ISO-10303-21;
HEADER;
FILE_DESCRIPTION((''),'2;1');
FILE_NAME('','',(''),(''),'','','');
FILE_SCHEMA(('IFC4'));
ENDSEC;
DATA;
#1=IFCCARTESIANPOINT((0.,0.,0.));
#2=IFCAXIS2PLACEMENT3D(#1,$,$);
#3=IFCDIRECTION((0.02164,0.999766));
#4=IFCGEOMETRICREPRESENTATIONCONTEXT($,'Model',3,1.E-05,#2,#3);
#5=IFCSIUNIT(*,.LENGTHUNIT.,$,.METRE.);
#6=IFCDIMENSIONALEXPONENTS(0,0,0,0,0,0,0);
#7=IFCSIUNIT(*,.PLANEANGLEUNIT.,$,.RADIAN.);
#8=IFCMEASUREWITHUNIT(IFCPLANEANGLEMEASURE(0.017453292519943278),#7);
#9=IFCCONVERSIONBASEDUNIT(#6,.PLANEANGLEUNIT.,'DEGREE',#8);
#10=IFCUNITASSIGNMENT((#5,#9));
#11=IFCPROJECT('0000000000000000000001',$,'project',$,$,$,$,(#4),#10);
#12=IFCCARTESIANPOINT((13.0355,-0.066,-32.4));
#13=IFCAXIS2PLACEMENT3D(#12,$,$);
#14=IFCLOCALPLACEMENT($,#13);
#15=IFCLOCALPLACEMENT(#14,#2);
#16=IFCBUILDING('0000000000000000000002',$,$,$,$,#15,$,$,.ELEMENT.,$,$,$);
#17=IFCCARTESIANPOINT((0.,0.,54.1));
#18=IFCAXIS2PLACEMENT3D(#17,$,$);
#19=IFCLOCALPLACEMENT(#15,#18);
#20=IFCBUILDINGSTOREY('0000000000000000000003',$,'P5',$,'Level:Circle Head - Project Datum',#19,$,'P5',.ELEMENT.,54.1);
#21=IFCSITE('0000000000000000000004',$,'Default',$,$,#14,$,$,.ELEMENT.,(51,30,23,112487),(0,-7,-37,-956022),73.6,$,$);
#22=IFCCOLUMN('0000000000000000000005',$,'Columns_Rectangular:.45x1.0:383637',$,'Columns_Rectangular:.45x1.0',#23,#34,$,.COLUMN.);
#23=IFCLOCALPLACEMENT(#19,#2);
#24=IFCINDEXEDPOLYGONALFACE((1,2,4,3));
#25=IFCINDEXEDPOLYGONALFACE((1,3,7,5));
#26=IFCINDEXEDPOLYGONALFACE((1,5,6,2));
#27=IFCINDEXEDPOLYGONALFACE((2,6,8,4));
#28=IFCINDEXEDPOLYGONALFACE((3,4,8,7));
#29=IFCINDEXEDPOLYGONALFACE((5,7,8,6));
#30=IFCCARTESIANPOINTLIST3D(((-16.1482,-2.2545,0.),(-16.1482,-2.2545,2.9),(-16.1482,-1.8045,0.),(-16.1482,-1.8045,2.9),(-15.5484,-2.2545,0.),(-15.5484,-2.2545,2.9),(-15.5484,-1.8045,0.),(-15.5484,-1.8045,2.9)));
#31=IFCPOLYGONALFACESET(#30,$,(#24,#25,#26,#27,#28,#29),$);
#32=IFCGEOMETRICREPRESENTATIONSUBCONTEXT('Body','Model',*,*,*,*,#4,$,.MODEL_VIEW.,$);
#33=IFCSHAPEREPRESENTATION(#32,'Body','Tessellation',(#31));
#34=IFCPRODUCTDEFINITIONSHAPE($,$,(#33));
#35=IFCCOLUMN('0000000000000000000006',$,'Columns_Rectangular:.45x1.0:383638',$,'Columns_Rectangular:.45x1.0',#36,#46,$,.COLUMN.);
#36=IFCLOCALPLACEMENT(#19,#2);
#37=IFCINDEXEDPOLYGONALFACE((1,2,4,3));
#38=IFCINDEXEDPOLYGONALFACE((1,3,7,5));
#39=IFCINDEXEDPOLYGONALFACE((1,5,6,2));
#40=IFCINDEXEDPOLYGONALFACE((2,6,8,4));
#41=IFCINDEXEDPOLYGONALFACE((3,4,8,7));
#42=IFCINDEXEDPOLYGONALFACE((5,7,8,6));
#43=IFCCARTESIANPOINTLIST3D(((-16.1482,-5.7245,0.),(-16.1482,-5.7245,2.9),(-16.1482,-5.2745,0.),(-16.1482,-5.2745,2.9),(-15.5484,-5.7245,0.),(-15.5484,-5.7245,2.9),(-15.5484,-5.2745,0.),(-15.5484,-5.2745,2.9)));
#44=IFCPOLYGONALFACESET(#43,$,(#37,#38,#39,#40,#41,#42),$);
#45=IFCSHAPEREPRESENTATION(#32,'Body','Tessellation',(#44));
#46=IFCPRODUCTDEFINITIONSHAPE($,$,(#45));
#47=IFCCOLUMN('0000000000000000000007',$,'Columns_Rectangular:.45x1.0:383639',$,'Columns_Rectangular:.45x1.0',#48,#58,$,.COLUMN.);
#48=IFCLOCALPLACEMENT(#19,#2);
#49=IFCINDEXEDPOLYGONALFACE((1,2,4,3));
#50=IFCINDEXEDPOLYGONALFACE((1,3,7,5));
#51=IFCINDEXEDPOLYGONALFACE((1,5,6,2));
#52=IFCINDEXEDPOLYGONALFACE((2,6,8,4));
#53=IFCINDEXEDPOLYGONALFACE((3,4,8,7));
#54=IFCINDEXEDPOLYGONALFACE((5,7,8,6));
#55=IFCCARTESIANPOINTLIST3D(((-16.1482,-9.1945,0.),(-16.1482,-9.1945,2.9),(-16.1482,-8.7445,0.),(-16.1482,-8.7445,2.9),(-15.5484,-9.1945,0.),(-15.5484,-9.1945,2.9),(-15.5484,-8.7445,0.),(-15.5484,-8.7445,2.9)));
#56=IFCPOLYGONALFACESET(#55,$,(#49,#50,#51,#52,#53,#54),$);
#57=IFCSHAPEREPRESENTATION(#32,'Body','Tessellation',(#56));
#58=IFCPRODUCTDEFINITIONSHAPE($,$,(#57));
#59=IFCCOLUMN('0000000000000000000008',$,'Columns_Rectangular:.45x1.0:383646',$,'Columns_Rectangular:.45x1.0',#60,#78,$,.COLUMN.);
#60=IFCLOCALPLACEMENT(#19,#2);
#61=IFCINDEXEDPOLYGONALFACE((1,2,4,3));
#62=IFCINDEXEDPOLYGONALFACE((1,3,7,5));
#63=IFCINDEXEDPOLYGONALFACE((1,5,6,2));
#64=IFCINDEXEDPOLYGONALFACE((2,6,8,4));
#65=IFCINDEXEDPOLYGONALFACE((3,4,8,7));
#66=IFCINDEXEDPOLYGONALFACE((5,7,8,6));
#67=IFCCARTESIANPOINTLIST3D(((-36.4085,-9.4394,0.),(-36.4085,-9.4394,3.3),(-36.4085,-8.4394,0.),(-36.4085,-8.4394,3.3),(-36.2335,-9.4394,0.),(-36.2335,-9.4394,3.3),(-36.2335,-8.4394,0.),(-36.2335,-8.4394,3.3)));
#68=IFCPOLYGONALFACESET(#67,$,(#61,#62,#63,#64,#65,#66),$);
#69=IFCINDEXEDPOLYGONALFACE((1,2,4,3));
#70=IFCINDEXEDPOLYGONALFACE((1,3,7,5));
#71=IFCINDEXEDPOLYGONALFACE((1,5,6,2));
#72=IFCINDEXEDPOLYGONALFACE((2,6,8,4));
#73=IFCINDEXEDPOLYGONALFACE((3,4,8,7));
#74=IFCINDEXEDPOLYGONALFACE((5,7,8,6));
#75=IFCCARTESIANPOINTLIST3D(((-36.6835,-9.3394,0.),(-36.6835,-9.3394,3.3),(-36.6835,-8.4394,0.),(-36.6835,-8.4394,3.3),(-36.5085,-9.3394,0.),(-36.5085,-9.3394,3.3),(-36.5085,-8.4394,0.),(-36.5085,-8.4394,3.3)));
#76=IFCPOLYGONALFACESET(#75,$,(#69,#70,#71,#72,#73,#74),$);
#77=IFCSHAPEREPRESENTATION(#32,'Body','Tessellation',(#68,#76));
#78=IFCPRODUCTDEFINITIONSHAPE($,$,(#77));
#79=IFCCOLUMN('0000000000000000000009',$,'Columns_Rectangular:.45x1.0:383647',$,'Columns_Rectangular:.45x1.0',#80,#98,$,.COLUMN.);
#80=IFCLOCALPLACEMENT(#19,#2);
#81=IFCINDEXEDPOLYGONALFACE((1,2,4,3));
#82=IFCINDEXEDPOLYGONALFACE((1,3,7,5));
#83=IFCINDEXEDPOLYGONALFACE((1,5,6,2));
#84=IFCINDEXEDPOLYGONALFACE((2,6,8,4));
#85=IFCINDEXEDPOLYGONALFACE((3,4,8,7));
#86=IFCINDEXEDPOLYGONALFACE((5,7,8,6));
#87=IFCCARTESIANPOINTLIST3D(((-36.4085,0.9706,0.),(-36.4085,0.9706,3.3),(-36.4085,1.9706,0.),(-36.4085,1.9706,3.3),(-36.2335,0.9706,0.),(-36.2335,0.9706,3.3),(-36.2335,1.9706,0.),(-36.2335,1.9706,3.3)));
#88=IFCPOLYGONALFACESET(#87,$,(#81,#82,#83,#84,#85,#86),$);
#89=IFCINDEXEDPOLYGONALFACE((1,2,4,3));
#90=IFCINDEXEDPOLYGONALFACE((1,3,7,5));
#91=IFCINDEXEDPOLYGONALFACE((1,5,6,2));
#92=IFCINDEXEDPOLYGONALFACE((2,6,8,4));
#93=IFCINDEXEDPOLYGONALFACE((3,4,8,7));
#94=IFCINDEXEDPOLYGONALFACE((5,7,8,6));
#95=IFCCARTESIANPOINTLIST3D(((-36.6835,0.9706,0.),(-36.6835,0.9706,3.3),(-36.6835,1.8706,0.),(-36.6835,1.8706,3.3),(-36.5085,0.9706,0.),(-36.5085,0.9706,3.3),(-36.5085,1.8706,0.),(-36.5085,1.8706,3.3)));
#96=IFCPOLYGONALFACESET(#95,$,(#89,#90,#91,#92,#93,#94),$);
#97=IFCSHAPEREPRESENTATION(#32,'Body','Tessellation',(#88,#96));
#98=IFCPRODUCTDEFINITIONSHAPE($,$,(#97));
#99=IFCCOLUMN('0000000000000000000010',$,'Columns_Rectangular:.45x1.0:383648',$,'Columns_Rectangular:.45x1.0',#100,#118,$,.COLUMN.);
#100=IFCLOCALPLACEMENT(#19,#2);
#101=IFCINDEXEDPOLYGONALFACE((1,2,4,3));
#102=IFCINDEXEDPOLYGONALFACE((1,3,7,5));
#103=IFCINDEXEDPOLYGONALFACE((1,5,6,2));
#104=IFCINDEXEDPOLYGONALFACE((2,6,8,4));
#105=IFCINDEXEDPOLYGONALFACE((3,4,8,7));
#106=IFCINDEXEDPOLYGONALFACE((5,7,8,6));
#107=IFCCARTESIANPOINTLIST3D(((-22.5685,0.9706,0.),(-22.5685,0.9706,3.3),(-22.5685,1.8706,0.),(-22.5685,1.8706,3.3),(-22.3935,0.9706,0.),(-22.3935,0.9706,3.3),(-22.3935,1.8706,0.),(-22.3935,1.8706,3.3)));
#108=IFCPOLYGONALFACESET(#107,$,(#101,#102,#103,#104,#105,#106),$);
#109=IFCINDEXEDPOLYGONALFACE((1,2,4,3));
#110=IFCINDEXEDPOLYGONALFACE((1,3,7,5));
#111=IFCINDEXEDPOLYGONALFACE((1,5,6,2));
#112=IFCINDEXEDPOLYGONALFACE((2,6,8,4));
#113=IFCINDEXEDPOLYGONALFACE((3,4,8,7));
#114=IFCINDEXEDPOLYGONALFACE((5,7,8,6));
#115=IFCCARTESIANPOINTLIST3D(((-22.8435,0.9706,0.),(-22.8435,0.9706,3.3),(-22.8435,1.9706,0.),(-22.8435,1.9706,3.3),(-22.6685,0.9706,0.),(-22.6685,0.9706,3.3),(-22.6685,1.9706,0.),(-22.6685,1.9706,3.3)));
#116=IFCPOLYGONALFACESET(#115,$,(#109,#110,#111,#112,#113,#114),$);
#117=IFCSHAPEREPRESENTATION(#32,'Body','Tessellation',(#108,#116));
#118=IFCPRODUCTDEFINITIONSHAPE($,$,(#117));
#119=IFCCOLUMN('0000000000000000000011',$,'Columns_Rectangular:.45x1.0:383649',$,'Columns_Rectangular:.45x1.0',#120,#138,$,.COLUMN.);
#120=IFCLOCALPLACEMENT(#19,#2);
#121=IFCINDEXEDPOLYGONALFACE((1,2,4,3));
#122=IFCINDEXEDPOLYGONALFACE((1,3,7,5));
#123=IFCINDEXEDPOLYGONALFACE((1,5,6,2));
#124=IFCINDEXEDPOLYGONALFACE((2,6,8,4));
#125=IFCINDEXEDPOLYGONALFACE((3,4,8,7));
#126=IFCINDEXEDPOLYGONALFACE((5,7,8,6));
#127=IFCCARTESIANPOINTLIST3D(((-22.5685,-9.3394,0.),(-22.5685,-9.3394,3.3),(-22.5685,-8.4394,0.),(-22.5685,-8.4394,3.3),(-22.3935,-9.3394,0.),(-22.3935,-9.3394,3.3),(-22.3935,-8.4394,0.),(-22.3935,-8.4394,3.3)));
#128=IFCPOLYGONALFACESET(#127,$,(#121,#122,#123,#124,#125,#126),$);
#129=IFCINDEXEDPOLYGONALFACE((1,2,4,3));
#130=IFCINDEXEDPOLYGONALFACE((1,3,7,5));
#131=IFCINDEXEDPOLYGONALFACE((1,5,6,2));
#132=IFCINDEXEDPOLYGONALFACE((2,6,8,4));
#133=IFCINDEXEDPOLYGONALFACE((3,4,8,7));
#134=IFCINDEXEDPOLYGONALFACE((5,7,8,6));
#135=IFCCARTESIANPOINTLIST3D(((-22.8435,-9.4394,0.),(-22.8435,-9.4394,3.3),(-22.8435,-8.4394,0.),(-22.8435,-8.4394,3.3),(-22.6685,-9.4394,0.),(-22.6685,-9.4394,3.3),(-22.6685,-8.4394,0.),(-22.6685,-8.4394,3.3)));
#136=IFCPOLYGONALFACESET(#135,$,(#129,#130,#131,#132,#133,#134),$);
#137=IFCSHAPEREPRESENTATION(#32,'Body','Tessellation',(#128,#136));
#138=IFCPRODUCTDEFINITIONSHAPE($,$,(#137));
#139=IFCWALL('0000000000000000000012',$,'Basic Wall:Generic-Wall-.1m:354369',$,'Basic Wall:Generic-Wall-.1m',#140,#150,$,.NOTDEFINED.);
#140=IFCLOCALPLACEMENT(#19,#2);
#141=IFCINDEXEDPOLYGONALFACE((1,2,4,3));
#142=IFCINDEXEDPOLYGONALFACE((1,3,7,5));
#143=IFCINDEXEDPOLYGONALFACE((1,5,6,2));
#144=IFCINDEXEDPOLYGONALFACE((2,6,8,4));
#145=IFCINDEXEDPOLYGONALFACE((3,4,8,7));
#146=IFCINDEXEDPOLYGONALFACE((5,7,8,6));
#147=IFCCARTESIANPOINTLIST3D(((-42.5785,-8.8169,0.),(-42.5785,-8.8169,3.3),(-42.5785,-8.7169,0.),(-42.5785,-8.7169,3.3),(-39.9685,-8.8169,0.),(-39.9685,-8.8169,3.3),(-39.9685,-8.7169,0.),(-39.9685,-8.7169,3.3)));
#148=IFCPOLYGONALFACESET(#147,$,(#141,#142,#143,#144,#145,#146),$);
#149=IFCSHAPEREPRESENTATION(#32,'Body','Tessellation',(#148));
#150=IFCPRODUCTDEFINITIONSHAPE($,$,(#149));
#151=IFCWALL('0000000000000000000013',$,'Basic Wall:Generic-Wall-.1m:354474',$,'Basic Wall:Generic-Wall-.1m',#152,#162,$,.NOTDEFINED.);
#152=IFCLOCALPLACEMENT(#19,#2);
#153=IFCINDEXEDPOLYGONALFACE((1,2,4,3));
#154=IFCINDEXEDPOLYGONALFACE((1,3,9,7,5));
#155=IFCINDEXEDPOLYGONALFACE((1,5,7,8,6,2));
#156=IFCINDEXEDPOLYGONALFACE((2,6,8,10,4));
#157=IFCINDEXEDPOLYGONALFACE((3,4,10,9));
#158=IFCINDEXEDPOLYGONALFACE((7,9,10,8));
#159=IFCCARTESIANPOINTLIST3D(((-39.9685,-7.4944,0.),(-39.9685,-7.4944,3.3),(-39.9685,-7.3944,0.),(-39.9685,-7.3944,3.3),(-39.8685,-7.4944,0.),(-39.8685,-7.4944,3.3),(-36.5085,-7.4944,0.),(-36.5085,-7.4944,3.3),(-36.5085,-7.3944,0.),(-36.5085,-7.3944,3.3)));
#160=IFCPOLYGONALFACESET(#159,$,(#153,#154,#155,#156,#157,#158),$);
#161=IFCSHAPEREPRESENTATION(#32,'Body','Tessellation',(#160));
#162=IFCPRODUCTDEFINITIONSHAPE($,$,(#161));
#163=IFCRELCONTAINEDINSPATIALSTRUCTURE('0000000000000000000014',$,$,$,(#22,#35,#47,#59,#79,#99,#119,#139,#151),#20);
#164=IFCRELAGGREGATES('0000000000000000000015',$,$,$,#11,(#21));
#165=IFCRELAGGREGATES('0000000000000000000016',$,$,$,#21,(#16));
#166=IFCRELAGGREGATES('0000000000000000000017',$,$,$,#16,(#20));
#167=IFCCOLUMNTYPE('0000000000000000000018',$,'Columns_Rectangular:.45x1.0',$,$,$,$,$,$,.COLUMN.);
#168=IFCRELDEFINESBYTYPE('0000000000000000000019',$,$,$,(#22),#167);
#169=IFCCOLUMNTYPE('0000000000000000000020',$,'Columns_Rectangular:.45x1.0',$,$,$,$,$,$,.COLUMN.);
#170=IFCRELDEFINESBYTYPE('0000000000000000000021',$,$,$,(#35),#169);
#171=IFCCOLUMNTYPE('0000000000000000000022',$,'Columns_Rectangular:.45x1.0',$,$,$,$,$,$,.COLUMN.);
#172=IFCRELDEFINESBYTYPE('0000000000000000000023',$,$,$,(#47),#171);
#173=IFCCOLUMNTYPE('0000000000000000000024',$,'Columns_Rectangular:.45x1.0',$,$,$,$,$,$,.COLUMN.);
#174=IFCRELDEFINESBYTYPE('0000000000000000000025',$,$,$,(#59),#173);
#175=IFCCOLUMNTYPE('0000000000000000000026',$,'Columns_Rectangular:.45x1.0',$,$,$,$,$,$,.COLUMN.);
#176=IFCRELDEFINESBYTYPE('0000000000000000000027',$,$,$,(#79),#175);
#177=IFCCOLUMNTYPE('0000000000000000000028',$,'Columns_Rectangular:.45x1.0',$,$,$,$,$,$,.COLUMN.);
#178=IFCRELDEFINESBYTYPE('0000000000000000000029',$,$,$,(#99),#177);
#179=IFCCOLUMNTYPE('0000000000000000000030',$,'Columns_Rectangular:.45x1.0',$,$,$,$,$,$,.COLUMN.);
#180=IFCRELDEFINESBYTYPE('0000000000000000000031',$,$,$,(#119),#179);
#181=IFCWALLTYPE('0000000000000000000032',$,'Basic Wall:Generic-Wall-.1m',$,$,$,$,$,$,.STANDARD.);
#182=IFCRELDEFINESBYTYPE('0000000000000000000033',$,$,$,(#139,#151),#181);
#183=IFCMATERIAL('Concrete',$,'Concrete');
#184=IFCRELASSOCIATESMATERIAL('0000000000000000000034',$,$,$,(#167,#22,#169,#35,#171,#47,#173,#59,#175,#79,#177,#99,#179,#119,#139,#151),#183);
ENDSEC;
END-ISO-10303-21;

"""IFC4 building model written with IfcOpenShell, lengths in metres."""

from ifc_helpers import new_model, entity, si_unit, converted_unit, direction, frame, origin, place, context, subcontext, project, spatial, indexed_curve, outline, extrude, source, transform, mapped, material, type_object, type_shapes, element, save


model = new_model("IFC4")

# Units and contexts
model_context = context("Model", 3, precision=1e-05, world=origin(), true_north=direction((0.02164, 0.999766)))
body_context = subcontext(model_context, "Body", "Model", "MODEL_VIEW")
ifc_project = project(units=[si_unit("LENGTHUNIT", "METRE"), converted_unit("PLANEANGLEUNIT", "DEGREE", entity("IfcPlaneAngleMeasure", 0.017453292519943278), si_unit("PLANEANGLEUNIT", "RADIAN"), dimensions=[0, 0, 0, 0, 0, 0, 0])], contexts=[model_context])

# Site, building, storey
site_placement = place(None, frame((13.0355, -0.066, -32.4)))
site = spatial("IfcSite", under=ifc_project, at=site_placement, Name="Default", CompositionType="ELEMENT", RefLatitude=(51, 30, 23, 112487), RefLongitude=(0, -7, -37, -956022), RefElevation=73.6)
building_placement = place(site_placement, origin())
building = spatial("IfcBuilding", under=site, at=building_placement, CompositionType="ELEMENT")
storey_placement = place(building_placement, frame((0.0, 0.0, 54.1)))
storey = spatial("IfcBuildingStorey", under=building, at=storey_placement, Name="P5", ObjectType="Level:Circle Head - Project Datum", LongName="P5", CompositionType="ELEMENT", Elevation=54.1)

# Columns
ifc_material = material(Name="Concrete", Category="Concrete")
column_type_1 = type_object("IfcColumnType", Name="Columns_Rectangular:.45x1.0", PredefinedType="COLUMN", material=ifc_material)
shared_shape_1 = source(origin(), body_context, "Body", "SweptSolid", [
    extrude(outline(indexed_curve([(-0.2999, -0.225), (0.2999, -0.225), (0.2999, 0.225), (-0.2999, 0.225), (-0.2999, -0.225)], self_intersect=False)), frame((-15.8483, -2.0295, 54.1), z_axis=(0.0, 0.0, 1.0), x_axis=(-1.0, 0.0, 0.0)), (0.0, 0.0, 1.0), 2.9),
])
type_shapes(column_type_1, [shared_shape_1])
column_1_placement = place(storey_placement, frame((0.0, 0.0, -54.1)))
element("IfcColumn", 1, at=column_1_placement, inside=storey, type_object=column_type_1, material=ifc_material, Name="Columns_Rectangular:.45x1.0:383637", ObjectType="Columns_Rectangular:.45x1.0", PredefinedType="COLUMN", context=body_context, shape_type="MappedRepresentation", body=[
    mapped(shared_shape_1, transform((0.0, 0.0, 0.0), scale=1.0)),
])
column_type_2 = type_object("IfcColumnType", Name="Columns_Rectangular:.45x1.0", PredefinedType="COLUMN", material=ifc_material)
shared_shape_2 = source(origin(), body_context, "Body", "SweptSolid", [
    extrude(outline(indexed_curve([(-0.2999, -0.225), (0.2999, -0.225), (0.2999, 0.225), (-0.2999, 0.225), (-0.2999, -0.225)], self_intersect=False)), frame((-15.8483, -5.4995, 54.1), z_axis=(0.0, 0.0, 1.0), x_axis=(-1.0, 0.0, 0.0)), (0.0, 0.0, 1.0), 2.9),
])
type_shapes(column_type_2, [shared_shape_2])
column_2_placement = place(storey_placement, frame((0.0, 0.0, -54.1)))
element("IfcColumn", 2, at=column_2_placement, inside=storey, type_object=column_type_2, material=ifc_material, Name="Columns_Rectangular:.45x1.0:383638", ObjectType="Columns_Rectangular:.45x1.0", PredefinedType="COLUMN", context=body_context, shape_type="MappedRepresentation", body=[
    mapped(shared_shape_2, transform((0.0, 0.0, 0.0), scale=1.0)),
])
column_type_3 = type_object("IfcColumnType", Name="Columns_Rectangular:.45x1.0", PredefinedType="COLUMN", material=ifc_material)
shared_shape_3 = source(origin(), body_context, "Body", "SweptSolid", [
    extrude(outline(indexed_curve([(-0.2999, -0.225), (0.2999, -0.225), (0.2999, 0.225), (-0.2999, 0.225), (-0.2999, -0.225)], self_intersect=False)), frame((-15.8483, -8.9695, 54.1), z_axis=(0.0, 0.0, 1.0), x_axis=(-1.0, 0.0, 0.0)), (0.0, 0.0, 1.0), 2.9),
])
type_shapes(column_type_3, [shared_shape_3])
column_3_placement = place(storey_placement, frame((0.0, 0.0, -54.1)))
element("IfcColumn", 3, at=column_3_placement, inside=storey, type_object=column_type_3, material=ifc_material, Name="Columns_Rectangular:.45x1.0:383639", ObjectType="Columns_Rectangular:.45x1.0", PredefinedType="COLUMN", context=body_context, shape_type="MappedRepresentation", body=[
    mapped(shared_shape_3, transform((0.0, 0.0, 0.0), scale=1.0)),
])
column_type_4 = type_object("IfcColumnType", Name="Columns_Rectangular:.45x1.0", PredefinedType="COLUMN", material=ifc_material)
shared_shape_4 = source(origin(), body_context, "Body", "SweptSolid", [
    extrude(outline(indexed_curve([(-0.0875, -0.5), (0.0875, -0.5), (0.0875, 0.5), (-0.0875, 0.5), (-0.0875, -0.5)], self_intersect=False)), frame((-36.321, -8.9394, 54.1), z_axis=(0.0, 0.0, 1.0), x_axis=(-1.0, 0.0, 0.0)), (0.0, 0.0, 1.0), 3.3),
    extrude(outline(indexed_curve([(-0.45, -0.0875), (0.45, -0.0875), (0.45, 0.0875), (-0.45, 0.0875), (-0.45, -0.0875)], self_intersect=False)), frame((-36.596, -8.8894, 54.1), z_axis=(0.0, 0.0, 1.0), x_axis=(0.0, -1.0, 0.0)), (0.0, 0.0, 1.0), 3.3),
])
type_shapes(column_type_4, [shared_shape_4])
column_4_placement = place(storey_placement, frame((0.0, 0.0, -54.1)))
element("IfcColumn", 4, at=column_4_placement, inside=storey, type_object=column_type_4, material=ifc_material, Name="Columns_Rectangular:.45x1.0:383646", ObjectType="Columns_Rectangular:.45x1.0", PredefinedType="COLUMN", context=body_context, shape_type="MappedRepresentation", body=[
    mapped(shared_shape_4, transform((0.0, 0.0, 0.0), scale=1.0)),
])
column_type_5 = type_object("IfcColumnType", Name="Columns_Rectangular:.45x1.0", PredefinedType="COLUMN", material=ifc_material)
shared_shape_5 = source(origin(), body_context, "Body", "SweptSolid", [
    extrude(outline(indexed_curve([(-0.0875, -0.5), (0.0875, -0.5), (0.0875, 0.5), (-0.0875, 0.5), (-0.0875, -0.5)], self_intersect=False)), frame((-36.321, 1.4706, 54.1), z_axis=(0.0, 0.0, 1.0), x_axis=(-1.0, 0.0, 0.0)), (0.0, 0.0, 1.0), 3.3),
    extrude(outline(indexed_curve([(-0.45, -0.0875), (0.45, -0.0875), (0.45, 0.0875), (-0.45, 0.0875), (-0.45, -0.0875)], self_intersect=False)), frame((-36.596, 1.4206, 54.1), z_axis=(0.0, 0.0, 1.0), x_axis=(0.0, 1.0, 0.0)), (0.0, 0.0, 1.0), 3.3),
])
type_shapes(column_type_5, [shared_shape_5])
column_5_placement = place(storey_placement, frame((0.0, 0.0, -54.1)))
element("IfcColumn", 5, at=column_5_placement, inside=storey, type_object=column_type_5, material=ifc_material, Name="Columns_Rectangular:.45x1.0:383647", ObjectType="Columns_Rectangular:.45x1.0", PredefinedType="COLUMN", context=body_context, shape_type="MappedRepresentation", body=[
    mapped(shared_shape_5, transform((0.0, 0.0, 0.0), scale=1.0)),
])
column_type_6 = type_object("IfcColumnType", Name="Columns_Rectangular:.45x1.0", PredefinedType="COLUMN", material=ifc_material)
shared_shape_6 = source(origin(), body_context, "Body", "SweptSolid", [
    extrude(outline(indexed_curve([(-0.45, -0.0875), (0.45, -0.0875), (0.45, 0.0875), (-0.45, 0.0875), (-0.45, -0.0875)], self_intersect=False)), frame((-22.481, 1.4206, 54.1), z_axis=(0.0, 0.0, 1.0), x_axis=(0.0, 1.0, 0.0)), (0.0, 0.0, 1.0), 3.3),
    extrude(outline(indexed_curve([(-0.0875, -0.5), (0.0875, -0.5), (0.0875, 0.5), (-0.0875, 0.5), (-0.0875, -0.5)], self_intersect=False)), frame((-22.756, 1.4706, 54.1)), (0.0, 0.0, 1.0), 3.3),
])
type_shapes(column_type_6, [shared_shape_6])
column_6_placement = place(storey_placement, frame((0.0, 0.0, -54.1)))
element("IfcColumn", 6, at=column_6_placement, inside=storey, type_object=column_type_6, material=ifc_material, Name="Columns_Rectangular:.45x1.0:383648", ObjectType="Columns_Rectangular:.45x1.0", PredefinedType="COLUMN", context=body_context, shape_type="MappedRepresentation", body=[
    mapped(shared_shape_6, transform((0.0, 0.0, 0.0), scale=1.0)),
])
column_type_7 = type_object("IfcColumnType", Name="Columns_Rectangular:.45x1.0", PredefinedType="COLUMN", material=ifc_material)
shared_shape_7 = source(origin(), body_context, "Body", "SweptSolid", [
    extrude(outline(indexed_curve([(-0.45, -0.0875), (0.45, -0.0875), (0.45, 0.0875), (-0.45, 0.0875), (-0.45, -0.0875)], self_intersect=False)), frame((-22.481, -8.8894, 54.1), z_axis=(0.0, 0.0, 1.0), x_axis=(0.0, -1.0, 0.0)), (0.0, 0.0, 1.0), 3.3),
    extrude(outline(indexed_curve([(-0.0875, -0.5), (0.0875, -0.5), (0.0875, 0.5), (-0.0875, 0.5), (-0.0875, -0.5)], self_intersect=False)), frame((-22.756, -8.9394, 54.1)), (0.0, 0.0, 1.0), 3.3),
])
type_shapes(column_type_7, [shared_shape_7])
column_7_placement = place(storey_placement, frame((0.0, 0.0, -54.1)))
element("IfcColumn", 7, at=column_7_placement, inside=storey, type_object=column_type_7, material=ifc_material, Name="Columns_Rectangular:.45x1.0:383649", ObjectType="Columns_Rectangular:.45x1.0", PredefinedType="COLUMN", context=body_context, shape_type="MappedRepresentation", body=[
    mapped(shared_shape_7, transform((0.0, 0.0, 0.0), scale=1.0)),
])

# Walls
wall_type = type_object("IfcWallType", Name="Basic Wall:Generic-Wall-.1m", PredefinedType="STANDARD")
wall_1_placement = place(storey_placement, frame((-39.9685, -8.7669, 0.0), z_axis=(0.0, 0.0, 1.0), x_axis=(-1.0, 0.0, 0.0)))
element("IfcWall", 8, at=wall_1_placement, inside=storey, type_object=wall_type, material=ifc_material, Name="Basic Wall:Generic-Wall-.1m:354369", ObjectType="Basic Wall:Generic-Wall-.1m", PredefinedType="NOTDEFINED", context=body_context, shape_type="SweptSolid", body=[
    extrude(outline(indexed_curve([(2.61, -0.05), (2.61, 0.05), (0.0, 0.05), (0.0, -0.05), (2.61, -0.05)], self_intersect=False)), origin(), (0.0, 0.0, 1.0), 3.3),
])
wall_2_placement = place(storey_placement, frame((-36.5085, -7.4444, 0.0), z_axis=(0.0, 0.0, 1.0), x_axis=(-1.0, 0.0, 0.0)))
element("IfcWall", 9, at=wall_2_placement, inside=storey, type_object=wall_type, material=ifc_material, Name="Basic Wall:Generic-Wall-.1m:354474", ObjectType="Basic Wall:Generic-Wall-.1m", PredefinedType="NOTDEFINED", context=body_context, shape_type="SweptSolid", body=[
    extrude(outline(indexed_curve([(3.46, -0.05), (3.46, 0.05), (3.36, 0.05), (0.0, 0.05), (0.0, -0.05), (3.46, -0.05)], self_intersect=False)), origin(), (0.0, 0.0, 1.0), 3.3),
])

save(model, "model.ifc")
